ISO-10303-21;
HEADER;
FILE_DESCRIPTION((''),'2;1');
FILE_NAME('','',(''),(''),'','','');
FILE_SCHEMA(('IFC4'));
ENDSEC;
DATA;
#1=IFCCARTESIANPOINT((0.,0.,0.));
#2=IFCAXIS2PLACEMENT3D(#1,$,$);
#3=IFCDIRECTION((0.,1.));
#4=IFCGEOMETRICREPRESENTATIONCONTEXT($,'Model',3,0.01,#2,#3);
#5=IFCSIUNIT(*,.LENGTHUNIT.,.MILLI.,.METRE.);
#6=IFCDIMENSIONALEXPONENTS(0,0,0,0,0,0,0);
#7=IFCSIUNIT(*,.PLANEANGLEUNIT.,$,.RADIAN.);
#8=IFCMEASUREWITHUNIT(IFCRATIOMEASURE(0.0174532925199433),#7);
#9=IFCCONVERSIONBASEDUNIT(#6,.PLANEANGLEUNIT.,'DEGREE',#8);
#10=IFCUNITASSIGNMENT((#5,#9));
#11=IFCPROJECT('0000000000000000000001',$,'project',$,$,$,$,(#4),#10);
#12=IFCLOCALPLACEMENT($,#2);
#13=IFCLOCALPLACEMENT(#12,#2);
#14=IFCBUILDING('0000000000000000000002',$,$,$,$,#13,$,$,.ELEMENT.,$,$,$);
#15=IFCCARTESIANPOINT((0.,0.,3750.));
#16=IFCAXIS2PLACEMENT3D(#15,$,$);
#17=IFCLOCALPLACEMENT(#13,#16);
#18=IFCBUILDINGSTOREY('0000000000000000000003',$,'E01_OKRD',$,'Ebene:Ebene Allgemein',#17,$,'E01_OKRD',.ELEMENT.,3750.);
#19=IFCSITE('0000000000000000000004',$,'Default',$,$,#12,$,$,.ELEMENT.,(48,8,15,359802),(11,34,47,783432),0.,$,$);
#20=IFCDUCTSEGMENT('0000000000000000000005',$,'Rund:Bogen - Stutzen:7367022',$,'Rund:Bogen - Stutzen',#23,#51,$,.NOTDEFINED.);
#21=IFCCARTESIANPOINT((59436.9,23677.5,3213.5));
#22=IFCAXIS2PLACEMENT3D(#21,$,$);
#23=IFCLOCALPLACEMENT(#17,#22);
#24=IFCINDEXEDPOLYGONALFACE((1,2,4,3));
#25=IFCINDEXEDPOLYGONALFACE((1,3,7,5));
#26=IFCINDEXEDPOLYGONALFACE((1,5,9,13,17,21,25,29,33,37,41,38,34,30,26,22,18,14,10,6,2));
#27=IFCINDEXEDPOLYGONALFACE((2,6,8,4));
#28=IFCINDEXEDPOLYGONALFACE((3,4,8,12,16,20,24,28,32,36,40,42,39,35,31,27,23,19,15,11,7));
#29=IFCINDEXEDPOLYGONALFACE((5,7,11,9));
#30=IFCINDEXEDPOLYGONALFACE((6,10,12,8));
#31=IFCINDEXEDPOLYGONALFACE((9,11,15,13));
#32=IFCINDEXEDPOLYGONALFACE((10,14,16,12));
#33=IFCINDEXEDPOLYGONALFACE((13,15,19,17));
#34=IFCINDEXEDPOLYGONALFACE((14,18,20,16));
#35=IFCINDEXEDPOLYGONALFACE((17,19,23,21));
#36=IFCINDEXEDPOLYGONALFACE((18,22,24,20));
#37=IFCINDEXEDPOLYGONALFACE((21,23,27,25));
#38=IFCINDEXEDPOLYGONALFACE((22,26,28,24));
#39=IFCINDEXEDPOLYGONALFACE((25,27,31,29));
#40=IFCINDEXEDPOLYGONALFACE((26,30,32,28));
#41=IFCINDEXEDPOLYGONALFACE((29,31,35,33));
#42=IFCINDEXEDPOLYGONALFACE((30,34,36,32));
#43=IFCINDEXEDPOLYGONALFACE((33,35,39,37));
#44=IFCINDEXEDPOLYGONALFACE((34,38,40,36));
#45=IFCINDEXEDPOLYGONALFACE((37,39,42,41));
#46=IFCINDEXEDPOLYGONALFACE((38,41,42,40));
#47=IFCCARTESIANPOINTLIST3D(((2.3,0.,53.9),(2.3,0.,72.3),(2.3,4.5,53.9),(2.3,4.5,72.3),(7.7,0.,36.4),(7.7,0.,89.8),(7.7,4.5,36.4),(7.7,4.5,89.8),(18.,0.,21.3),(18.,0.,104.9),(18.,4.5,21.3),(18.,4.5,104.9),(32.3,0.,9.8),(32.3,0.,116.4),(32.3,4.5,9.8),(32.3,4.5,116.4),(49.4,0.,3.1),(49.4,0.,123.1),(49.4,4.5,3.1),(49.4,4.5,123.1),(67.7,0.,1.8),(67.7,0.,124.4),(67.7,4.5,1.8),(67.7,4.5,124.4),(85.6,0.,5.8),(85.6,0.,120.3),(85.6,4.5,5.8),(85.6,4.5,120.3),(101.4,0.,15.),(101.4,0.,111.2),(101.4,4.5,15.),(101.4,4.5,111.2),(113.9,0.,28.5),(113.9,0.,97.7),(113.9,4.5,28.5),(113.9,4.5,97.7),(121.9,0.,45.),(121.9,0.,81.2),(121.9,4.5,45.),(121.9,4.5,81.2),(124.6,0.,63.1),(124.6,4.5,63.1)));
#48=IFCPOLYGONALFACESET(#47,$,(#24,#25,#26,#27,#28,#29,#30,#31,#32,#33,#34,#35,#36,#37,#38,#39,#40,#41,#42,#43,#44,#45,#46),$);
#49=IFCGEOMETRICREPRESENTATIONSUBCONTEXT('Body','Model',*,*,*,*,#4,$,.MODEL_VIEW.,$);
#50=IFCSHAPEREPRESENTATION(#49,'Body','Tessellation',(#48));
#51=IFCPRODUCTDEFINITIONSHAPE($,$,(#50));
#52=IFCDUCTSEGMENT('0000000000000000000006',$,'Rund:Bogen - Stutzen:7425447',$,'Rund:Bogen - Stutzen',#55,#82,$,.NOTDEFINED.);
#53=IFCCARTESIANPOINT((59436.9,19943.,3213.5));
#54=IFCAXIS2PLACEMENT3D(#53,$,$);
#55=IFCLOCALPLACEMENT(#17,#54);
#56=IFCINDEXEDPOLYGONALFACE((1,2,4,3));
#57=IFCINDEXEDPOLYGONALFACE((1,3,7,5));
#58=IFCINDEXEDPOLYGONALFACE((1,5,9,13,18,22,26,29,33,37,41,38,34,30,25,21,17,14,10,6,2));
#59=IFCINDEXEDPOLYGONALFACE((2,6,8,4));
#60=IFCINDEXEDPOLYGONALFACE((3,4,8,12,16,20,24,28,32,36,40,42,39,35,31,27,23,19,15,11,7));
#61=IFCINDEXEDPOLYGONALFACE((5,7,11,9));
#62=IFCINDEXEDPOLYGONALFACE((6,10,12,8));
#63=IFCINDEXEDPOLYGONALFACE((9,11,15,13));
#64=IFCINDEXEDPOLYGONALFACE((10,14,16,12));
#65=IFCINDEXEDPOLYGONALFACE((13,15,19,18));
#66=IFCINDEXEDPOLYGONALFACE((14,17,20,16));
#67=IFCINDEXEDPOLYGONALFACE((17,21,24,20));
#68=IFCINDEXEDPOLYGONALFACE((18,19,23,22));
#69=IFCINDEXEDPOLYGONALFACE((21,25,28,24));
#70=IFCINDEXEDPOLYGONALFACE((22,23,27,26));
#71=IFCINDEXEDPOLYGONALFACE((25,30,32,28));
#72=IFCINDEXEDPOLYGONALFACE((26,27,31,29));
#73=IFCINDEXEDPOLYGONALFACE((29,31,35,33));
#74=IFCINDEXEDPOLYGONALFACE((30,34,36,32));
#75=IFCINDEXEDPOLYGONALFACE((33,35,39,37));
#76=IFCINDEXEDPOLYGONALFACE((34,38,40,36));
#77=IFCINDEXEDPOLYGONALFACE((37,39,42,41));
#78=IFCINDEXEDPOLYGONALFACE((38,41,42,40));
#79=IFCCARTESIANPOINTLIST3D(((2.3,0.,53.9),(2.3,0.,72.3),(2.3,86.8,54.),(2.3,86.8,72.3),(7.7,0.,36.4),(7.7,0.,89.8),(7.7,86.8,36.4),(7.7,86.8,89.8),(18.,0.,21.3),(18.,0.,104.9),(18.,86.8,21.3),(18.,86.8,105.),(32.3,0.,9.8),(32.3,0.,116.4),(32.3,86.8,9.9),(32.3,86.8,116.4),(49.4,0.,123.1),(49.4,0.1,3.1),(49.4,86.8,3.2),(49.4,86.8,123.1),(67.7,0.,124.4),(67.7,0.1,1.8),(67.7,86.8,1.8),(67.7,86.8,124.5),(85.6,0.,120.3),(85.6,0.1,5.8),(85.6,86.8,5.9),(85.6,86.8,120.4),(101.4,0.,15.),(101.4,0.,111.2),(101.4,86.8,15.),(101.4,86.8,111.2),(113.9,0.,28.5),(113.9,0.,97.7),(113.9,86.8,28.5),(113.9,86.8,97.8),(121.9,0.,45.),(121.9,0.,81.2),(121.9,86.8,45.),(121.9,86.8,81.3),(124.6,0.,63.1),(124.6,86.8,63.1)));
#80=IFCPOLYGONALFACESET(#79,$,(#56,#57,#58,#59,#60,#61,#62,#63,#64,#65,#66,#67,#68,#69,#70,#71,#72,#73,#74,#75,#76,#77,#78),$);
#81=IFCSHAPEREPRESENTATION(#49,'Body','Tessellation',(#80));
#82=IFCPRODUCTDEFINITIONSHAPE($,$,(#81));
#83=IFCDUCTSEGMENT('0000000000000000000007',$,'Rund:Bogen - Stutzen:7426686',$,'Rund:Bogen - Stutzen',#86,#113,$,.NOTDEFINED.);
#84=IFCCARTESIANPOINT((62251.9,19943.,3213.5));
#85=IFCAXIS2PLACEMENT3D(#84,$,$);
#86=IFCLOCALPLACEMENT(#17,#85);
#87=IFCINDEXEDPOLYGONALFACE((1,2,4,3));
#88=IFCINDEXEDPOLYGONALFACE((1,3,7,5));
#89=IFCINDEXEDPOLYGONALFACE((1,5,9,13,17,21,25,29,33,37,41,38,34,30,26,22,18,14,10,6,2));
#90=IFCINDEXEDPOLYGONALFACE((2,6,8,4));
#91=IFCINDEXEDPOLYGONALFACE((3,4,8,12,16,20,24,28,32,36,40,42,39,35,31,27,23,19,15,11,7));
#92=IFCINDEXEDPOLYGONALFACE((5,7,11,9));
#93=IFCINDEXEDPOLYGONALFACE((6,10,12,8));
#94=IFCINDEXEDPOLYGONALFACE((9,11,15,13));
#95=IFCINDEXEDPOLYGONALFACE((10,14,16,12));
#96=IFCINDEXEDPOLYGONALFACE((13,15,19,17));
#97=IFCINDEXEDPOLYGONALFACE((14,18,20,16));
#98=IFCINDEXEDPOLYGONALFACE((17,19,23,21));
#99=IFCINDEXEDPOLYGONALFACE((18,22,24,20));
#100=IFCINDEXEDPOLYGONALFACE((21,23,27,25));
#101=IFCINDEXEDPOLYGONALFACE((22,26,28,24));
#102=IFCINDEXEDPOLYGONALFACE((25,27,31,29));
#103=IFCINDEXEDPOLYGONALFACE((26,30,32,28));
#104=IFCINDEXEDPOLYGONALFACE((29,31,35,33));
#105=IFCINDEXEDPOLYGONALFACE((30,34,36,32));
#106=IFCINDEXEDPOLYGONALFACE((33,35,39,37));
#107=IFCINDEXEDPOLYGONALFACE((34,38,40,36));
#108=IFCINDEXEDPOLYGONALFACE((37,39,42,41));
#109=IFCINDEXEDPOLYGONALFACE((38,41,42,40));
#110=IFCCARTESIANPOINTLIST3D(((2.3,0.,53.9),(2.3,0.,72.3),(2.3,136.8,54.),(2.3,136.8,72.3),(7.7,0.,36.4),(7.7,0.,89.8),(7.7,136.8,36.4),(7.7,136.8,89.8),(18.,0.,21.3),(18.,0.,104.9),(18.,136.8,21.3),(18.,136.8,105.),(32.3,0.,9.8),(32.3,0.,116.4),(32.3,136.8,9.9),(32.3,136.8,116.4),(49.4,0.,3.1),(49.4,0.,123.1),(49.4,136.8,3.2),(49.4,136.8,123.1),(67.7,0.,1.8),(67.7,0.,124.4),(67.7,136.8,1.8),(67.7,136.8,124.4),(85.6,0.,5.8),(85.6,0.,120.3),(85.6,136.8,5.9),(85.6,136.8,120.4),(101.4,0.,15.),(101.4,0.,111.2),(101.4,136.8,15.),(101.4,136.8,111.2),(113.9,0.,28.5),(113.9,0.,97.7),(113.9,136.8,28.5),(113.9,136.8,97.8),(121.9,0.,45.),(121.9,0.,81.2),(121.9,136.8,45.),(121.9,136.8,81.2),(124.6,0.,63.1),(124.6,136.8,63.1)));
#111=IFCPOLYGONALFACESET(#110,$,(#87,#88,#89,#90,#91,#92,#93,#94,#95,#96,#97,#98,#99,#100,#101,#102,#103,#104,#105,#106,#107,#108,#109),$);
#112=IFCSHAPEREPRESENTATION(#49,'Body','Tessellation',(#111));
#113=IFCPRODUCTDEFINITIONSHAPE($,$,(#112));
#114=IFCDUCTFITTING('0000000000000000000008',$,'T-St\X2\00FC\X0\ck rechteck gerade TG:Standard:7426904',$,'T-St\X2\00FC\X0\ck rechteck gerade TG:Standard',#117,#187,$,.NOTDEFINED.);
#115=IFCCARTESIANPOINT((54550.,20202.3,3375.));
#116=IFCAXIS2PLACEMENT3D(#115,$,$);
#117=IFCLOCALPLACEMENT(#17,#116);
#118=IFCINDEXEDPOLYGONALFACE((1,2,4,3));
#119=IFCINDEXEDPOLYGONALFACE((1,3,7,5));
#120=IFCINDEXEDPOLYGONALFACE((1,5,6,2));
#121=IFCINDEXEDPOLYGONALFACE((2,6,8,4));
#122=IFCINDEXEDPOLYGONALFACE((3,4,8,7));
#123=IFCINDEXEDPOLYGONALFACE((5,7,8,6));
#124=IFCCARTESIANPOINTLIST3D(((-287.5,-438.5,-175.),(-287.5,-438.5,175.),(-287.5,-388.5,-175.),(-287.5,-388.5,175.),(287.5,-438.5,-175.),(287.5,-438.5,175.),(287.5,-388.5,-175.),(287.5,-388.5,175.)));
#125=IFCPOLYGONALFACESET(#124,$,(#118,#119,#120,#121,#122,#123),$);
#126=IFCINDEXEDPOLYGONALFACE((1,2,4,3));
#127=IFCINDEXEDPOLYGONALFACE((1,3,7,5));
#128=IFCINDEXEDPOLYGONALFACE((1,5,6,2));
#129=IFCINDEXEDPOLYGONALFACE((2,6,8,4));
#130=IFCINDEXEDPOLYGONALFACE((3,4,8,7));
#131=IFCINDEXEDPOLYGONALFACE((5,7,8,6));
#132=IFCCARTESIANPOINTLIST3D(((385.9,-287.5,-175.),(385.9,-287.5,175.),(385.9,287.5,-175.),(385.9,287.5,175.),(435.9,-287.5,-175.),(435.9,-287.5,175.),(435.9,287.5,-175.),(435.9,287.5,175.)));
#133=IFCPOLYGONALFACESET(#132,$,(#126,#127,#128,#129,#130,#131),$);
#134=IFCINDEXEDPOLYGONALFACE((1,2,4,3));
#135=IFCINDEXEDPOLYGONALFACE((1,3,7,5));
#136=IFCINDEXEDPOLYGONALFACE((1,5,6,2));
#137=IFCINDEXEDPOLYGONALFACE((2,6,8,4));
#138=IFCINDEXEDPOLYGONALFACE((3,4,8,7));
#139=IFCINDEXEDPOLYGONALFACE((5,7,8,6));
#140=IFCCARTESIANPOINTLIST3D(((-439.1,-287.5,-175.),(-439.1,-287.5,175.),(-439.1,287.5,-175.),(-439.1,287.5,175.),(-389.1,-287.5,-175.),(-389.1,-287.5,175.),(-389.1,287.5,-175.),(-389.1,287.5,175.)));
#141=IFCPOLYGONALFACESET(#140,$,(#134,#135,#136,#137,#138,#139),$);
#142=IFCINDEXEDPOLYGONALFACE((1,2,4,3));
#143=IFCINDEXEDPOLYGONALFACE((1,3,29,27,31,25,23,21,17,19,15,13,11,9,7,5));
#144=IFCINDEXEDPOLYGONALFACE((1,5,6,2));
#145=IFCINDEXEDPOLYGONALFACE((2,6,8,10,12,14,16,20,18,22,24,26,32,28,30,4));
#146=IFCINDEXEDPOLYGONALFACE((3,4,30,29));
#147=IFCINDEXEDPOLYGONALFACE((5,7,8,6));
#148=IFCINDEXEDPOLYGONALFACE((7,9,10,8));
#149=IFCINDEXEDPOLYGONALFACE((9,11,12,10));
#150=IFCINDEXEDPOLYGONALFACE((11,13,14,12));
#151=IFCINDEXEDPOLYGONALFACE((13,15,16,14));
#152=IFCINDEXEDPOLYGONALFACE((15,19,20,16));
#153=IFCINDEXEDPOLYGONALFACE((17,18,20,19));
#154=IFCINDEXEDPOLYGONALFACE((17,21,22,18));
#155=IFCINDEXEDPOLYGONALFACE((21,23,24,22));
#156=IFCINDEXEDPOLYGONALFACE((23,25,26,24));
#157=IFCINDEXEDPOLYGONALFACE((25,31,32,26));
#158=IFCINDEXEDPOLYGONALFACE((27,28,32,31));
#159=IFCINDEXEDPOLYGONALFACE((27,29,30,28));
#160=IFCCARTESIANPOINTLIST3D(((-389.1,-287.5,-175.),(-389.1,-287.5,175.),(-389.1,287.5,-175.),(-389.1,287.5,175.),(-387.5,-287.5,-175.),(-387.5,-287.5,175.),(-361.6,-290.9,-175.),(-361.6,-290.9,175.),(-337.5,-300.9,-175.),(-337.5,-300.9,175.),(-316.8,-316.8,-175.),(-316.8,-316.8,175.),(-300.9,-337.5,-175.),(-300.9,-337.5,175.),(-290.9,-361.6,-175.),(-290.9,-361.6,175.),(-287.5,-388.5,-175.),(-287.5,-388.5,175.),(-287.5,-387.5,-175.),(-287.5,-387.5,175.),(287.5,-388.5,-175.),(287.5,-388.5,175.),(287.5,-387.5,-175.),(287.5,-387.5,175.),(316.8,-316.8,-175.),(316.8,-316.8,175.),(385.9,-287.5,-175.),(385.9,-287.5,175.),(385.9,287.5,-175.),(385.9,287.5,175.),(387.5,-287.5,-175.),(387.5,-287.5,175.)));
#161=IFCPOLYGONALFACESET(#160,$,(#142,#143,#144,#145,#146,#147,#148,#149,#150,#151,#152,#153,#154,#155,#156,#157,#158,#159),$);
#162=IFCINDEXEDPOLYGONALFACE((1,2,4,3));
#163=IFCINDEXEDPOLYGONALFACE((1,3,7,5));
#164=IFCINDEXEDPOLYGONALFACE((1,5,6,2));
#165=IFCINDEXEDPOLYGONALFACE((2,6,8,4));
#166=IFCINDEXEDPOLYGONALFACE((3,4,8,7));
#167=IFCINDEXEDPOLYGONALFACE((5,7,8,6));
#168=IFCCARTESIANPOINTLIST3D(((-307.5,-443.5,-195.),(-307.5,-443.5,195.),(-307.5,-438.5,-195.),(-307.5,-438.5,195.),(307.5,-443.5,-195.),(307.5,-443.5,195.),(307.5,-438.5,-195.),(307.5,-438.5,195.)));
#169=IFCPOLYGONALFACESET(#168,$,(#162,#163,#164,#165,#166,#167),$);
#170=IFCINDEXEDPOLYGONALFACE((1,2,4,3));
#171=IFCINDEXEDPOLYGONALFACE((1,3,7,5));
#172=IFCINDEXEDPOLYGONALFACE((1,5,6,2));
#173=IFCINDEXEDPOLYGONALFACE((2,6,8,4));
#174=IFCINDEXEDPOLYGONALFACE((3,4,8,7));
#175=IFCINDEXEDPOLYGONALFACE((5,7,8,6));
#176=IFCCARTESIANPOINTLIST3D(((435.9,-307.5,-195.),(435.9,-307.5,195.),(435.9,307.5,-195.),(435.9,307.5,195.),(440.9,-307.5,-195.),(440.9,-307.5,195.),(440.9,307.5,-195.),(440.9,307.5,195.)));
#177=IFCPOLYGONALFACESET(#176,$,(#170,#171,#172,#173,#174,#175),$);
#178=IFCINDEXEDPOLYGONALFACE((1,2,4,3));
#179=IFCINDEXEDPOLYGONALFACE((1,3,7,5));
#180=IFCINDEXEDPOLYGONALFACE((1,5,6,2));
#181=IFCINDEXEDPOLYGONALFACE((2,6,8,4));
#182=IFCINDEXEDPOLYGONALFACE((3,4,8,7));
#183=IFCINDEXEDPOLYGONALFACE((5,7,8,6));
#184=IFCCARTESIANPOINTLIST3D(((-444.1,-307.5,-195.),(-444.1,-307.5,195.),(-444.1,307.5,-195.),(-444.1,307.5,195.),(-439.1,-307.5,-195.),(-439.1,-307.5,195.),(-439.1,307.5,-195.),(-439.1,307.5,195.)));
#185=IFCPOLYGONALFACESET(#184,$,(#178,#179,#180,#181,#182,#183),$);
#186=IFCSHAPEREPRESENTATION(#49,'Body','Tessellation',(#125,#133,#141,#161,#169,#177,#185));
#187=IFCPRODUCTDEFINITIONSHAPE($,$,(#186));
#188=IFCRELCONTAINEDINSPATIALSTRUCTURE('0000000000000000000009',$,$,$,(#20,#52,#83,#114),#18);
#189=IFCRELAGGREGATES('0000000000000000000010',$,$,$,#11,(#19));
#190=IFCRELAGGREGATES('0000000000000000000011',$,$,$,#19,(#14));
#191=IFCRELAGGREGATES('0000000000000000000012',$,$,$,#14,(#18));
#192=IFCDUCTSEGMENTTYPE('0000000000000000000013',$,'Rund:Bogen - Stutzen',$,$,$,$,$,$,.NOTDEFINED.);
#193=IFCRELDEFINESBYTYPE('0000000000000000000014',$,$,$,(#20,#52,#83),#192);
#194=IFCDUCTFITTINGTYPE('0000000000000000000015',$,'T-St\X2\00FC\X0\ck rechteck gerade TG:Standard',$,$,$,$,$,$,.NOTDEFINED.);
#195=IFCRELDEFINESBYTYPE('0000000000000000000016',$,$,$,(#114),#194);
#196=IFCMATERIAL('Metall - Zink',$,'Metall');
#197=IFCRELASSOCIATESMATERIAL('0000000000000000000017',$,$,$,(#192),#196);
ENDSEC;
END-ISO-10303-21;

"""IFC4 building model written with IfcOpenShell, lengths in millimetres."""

from ifc_helpers import new_model, entity, si_unit, converted_unit, direction, frame, frame_2d, origin, origin_2d_with_axis, place, context, subcontext, project, spatial, polyline, circle_curve, parameter, trimmed, segment, composite_curve, rectangle, circle, outline, extrude, source, transform, mapped, material, type_object, type_shapes, element, save


model = new_model("IFC4")

# Units and contexts
model_context = context("Model", 3, precision=0.01, world=origin(), true_north=direction((0.0, 1.0)))
body_context = subcontext(model_context, "Body", "Model", "MODEL_VIEW")
ifc_project = project(units=[si_unit("LENGTHUNIT", "METRE", prefix="MILLI"), converted_unit("PLANEANGLEUNIT", "DEGREE", entity("IfcRatioMeasure", 0.0174532925199433), si_unit("PLANEANGLEUNIT", "RADIAN"), dimensions=[0, 0, 0, 0, 0, 0, 0])], contexts=[model_context])

# Site, building, storey
site_placement = place(None, origin())
site = spatial("IfcSite", under=ifc_project, at=site_placement, Name="Default", CompositionType="ELEMENT", RefLatitude=(48, 8, 15, 359802), RefLongitude=(11, 34, 47, 783432), RefElevation=0.0)
building_placement = place(site_placement, origin())
building = spatial("IfcBuilding", under=site, at=building_placement, CompositionType="ELEMENT")
storey_placement = place(building_placement, frame((0.0, 0.0, 3750.0)))
storey = spatial("IfcBuildingStorey", under=building, at=storey_placement, Name="E01_OKRD", ObjectType="Ebene:Ebene Allgemein", LongName="E01_OKRD", CompositionType="ELEMENT", Elevation=3750.0)

# Shared definitions
ifc_material_1 = material(Name="Metall - Zink", Category="Metall")

# Duct segments
duct_segment_type_1 = type_object("IfcDuctSegmentType", Name="Rund:Bogen - Stutzen", PredefinedType="NOTDEFINED", material=ifc_material_1)
duct_segment_1_placement = place(storey_placement, frame((59436.9, 23677.5, 3213.5)))
element("IfcDuctSegment", 1, at=duct_segment_1_placement, inside=storey, type_object=duct_segment_type_1, Name="Rund:Bogen - Stutzen:7367022", ObjectType="Rund:Bogen - Stutzen", PredefinedType="NOTDEFINED", context=body_context, shape_type="SweptSolid", body=[
    extrude(circle(Radius=61.5, at=frame_2d((0.0, 0.0), x_axis=(1.0, 0.0))), frame((63.1, 0.0, 63.1), z_axis=(0.0, 1.0, 0.0), x_axis=(1.0, 0.0, 0.0)), (0.0, 0.0, 1.0), 4.5),
])
duct_segment_2_placement = place(storey_placement, frame((59436.9, 19943.0, 3213.5)))
element("IfcDuctSegment", 2, at=duct_segment_2_placement, inside=storey, type_object=duct_segment_type_1, Name="Rund:Bogen - Stutzen:7425447", ObjectType="Rund:Bogen - Stutzen", PredefinedType="NOTDEFINED", context=body_context, shape_type="SweptSolid", body=[
    extrude(circle(Radius=61.5, at=frame_2d((0.0, 0.0), x_axis=(1.0, 0.0))), frame((63.1, 0.0, 63.1), z_axis=(0.0, 1.0, 0.000429), x_axis=(1.0, 0.0, 0.0)), (0.0, 0.0, 1.0), 86.8),
])
duct_segment_3_placement = place(storey_placement, frame((62251.9, 19943.0, 3213.5)))
element("IfcDuctSegment", 3, at=duct_segment_3_placement, inside=storey, type_object=duct_segment_type_1, Name="Rund:Bogen - Stutzen:7426686", ObjectType="Rund:Bogen - Stutzen", PredefinedType="NOTDEFINED", context=body_context, shape_type="SweptSolid", body=[
    extrude(circle(Radius=61.5, at=frame_2d((0.0, 0.0), x_axis=(1.0, 0.0))), frame((63.1, 0.0, 63.1), z_axis=(0.0, 1.0, 0.000188), x_axis=(1.0, 0.0, 0.0)), (0.0, 0.0, 1.0), 136.8),
])

# Duct fitting
duct_fitting_type_1 = type_object("IfcDuctFittingType", Name="T-Stück rechteck gerade TG:Standard", PredefinedType="NOTDEFINED")
shared_shape_1 = source(origin(), body_context, "Body", "SweptSolid", [
    extrude(rectangle(XDim=50.0, YDim=575.0, at=frame_2d((0.0, 0.0), x_axis=(1.0, 0.0))), frame((0.0, -413.5, -175.0), z_axis=(0.0, 0.0, 1.0), x_axis=(0.0, -1.0, 0.0)), (0.0, 0.0, 1.0), 350.0),
    extrude(rectangle(XDim=50.0, YDim=575.0, at=origin_2d_with_axis()), frame((410.9, 0.0, -175.0), z_axis=(0.0, 0.0, 1.0), x_axis=(-1.0, 0.0, 0.0)), (0.0, 0.0, 1.0), 350.0),
    extrude(rectangle(XDim=50.0, YDim=575.0, at=frame_2d((0.0, 0.0), x_axis=(1.0, 0.0))), frame((-414.1, 0.0, -175.0)), (0.0, 0.0, 1.0), 350.0),
    extrude(outline(composite_curve([segment(trimmed(circle_curve(frame_2d((-388.1, -174.8), x_axis=(-1.0, 0.0)), 100.0), [parameter(180.0)], [parameter(270.0)], True, "PARAMETER"), False, "CONTINUOUS"), segment(polyline([(-288.1, -174.8), (-288.1, -175.8)]), True, "CONTINUOUS"), segment(polyline([(-288.1, -175.8), (286.9, -175.8)]), True, "CONTINUOUS"), segment(polyline([(286.9, -175.8), (286.9, -174.8)]), True, "CONTINUOUS"), segment(trimmed(circle_curve(frame_2d((386.9, -174.8), x_axis=(-1.0, 0.0)), 100.0), [parameter(270.0)], [parameter(0.0)], True, "PARAMETER"), False, "CONTINUOUS"), segment(polyline([(386.9, -74.8), (388.5, -74.8)]), True, "CONTINUOUS"), segment(polyline([(388.5, -74.8), (388.5, 500.2)]), True, "CONTINUOUS"), segment(polyline([(388.5, 500.2), (-386.5, 500.2)]), True, "CONTINUOUS"), segment(polyline([(-386.5, 500.2), (-386.5, -74.8)]), True, "CONTINUOUS"), segment(polyline([(-386.5, -74.8), (-388.1, -74.8)]), True, "CONTINUOUS")], self_intersect=False)), frame((-0.6, -212.7, -175.0), z_axis=(0.0, 0.0, -1.0), x_axis=(-1.0, 0.0, 0.0)), (0.0, 0.0, -1.0), 350.0),
    extrude(rectangle(XDim=5.0, YDim=615.0, at=origin_2d_with_axis()), frame((0.0, -441.0, -195.0), z_axis=(0.0, 0.0, 1.0), x_axis=(0.0, 1.0, 0.0)), (0.0, 0.0, 1.0), 390.0),
    extrude(rectangle(XDim=5.0, YDim=615.0, at=frame_2d((0.0, 0.0), x_axis=(1.0, 0.0))), frame((438.4, 0.0, -195.0), z_axis=(0.0, 0.0, 1.0), x_axis=(-1.0, 0.0, 0.0)), (0.0, 0.0, 1.0), 390.0),
    extrude(rectangle(XDim=5.0, YDim=615.0, at=origin_2d_with_axis()), frame((-441.6, 0.0, -195.0), z_axis=(0.0, 0.0, 1.0), x_axis=(-1.0, 0.0, 0.0)), (0.0, 0.0, 1.0), 390.0),
])
type_shapes(duct_fitting_type_1, [shared_shape_1])
duct_fitting_1_placement = place(storey_placement, frame((54550.0, 20202.3, 3375.0)))
element("IfcDuctFitting", 4, at=duct_fitting_1_placement, inside=storey, type_object=duct_fitting_type_1, Name="T-Stück rechteck gerade TG:Standard:7426904", ObjectType="T-Stück rechteck gerade TG:Standard", PredefinedType="NOTDEFINED", context=body_context, shape_type="MappedRepresentation", body=[
    mapped(shared_shape_1, transform((0.0, 0.0, 0.0), scale=1.0)),
])

save(model, "model.ifc")
